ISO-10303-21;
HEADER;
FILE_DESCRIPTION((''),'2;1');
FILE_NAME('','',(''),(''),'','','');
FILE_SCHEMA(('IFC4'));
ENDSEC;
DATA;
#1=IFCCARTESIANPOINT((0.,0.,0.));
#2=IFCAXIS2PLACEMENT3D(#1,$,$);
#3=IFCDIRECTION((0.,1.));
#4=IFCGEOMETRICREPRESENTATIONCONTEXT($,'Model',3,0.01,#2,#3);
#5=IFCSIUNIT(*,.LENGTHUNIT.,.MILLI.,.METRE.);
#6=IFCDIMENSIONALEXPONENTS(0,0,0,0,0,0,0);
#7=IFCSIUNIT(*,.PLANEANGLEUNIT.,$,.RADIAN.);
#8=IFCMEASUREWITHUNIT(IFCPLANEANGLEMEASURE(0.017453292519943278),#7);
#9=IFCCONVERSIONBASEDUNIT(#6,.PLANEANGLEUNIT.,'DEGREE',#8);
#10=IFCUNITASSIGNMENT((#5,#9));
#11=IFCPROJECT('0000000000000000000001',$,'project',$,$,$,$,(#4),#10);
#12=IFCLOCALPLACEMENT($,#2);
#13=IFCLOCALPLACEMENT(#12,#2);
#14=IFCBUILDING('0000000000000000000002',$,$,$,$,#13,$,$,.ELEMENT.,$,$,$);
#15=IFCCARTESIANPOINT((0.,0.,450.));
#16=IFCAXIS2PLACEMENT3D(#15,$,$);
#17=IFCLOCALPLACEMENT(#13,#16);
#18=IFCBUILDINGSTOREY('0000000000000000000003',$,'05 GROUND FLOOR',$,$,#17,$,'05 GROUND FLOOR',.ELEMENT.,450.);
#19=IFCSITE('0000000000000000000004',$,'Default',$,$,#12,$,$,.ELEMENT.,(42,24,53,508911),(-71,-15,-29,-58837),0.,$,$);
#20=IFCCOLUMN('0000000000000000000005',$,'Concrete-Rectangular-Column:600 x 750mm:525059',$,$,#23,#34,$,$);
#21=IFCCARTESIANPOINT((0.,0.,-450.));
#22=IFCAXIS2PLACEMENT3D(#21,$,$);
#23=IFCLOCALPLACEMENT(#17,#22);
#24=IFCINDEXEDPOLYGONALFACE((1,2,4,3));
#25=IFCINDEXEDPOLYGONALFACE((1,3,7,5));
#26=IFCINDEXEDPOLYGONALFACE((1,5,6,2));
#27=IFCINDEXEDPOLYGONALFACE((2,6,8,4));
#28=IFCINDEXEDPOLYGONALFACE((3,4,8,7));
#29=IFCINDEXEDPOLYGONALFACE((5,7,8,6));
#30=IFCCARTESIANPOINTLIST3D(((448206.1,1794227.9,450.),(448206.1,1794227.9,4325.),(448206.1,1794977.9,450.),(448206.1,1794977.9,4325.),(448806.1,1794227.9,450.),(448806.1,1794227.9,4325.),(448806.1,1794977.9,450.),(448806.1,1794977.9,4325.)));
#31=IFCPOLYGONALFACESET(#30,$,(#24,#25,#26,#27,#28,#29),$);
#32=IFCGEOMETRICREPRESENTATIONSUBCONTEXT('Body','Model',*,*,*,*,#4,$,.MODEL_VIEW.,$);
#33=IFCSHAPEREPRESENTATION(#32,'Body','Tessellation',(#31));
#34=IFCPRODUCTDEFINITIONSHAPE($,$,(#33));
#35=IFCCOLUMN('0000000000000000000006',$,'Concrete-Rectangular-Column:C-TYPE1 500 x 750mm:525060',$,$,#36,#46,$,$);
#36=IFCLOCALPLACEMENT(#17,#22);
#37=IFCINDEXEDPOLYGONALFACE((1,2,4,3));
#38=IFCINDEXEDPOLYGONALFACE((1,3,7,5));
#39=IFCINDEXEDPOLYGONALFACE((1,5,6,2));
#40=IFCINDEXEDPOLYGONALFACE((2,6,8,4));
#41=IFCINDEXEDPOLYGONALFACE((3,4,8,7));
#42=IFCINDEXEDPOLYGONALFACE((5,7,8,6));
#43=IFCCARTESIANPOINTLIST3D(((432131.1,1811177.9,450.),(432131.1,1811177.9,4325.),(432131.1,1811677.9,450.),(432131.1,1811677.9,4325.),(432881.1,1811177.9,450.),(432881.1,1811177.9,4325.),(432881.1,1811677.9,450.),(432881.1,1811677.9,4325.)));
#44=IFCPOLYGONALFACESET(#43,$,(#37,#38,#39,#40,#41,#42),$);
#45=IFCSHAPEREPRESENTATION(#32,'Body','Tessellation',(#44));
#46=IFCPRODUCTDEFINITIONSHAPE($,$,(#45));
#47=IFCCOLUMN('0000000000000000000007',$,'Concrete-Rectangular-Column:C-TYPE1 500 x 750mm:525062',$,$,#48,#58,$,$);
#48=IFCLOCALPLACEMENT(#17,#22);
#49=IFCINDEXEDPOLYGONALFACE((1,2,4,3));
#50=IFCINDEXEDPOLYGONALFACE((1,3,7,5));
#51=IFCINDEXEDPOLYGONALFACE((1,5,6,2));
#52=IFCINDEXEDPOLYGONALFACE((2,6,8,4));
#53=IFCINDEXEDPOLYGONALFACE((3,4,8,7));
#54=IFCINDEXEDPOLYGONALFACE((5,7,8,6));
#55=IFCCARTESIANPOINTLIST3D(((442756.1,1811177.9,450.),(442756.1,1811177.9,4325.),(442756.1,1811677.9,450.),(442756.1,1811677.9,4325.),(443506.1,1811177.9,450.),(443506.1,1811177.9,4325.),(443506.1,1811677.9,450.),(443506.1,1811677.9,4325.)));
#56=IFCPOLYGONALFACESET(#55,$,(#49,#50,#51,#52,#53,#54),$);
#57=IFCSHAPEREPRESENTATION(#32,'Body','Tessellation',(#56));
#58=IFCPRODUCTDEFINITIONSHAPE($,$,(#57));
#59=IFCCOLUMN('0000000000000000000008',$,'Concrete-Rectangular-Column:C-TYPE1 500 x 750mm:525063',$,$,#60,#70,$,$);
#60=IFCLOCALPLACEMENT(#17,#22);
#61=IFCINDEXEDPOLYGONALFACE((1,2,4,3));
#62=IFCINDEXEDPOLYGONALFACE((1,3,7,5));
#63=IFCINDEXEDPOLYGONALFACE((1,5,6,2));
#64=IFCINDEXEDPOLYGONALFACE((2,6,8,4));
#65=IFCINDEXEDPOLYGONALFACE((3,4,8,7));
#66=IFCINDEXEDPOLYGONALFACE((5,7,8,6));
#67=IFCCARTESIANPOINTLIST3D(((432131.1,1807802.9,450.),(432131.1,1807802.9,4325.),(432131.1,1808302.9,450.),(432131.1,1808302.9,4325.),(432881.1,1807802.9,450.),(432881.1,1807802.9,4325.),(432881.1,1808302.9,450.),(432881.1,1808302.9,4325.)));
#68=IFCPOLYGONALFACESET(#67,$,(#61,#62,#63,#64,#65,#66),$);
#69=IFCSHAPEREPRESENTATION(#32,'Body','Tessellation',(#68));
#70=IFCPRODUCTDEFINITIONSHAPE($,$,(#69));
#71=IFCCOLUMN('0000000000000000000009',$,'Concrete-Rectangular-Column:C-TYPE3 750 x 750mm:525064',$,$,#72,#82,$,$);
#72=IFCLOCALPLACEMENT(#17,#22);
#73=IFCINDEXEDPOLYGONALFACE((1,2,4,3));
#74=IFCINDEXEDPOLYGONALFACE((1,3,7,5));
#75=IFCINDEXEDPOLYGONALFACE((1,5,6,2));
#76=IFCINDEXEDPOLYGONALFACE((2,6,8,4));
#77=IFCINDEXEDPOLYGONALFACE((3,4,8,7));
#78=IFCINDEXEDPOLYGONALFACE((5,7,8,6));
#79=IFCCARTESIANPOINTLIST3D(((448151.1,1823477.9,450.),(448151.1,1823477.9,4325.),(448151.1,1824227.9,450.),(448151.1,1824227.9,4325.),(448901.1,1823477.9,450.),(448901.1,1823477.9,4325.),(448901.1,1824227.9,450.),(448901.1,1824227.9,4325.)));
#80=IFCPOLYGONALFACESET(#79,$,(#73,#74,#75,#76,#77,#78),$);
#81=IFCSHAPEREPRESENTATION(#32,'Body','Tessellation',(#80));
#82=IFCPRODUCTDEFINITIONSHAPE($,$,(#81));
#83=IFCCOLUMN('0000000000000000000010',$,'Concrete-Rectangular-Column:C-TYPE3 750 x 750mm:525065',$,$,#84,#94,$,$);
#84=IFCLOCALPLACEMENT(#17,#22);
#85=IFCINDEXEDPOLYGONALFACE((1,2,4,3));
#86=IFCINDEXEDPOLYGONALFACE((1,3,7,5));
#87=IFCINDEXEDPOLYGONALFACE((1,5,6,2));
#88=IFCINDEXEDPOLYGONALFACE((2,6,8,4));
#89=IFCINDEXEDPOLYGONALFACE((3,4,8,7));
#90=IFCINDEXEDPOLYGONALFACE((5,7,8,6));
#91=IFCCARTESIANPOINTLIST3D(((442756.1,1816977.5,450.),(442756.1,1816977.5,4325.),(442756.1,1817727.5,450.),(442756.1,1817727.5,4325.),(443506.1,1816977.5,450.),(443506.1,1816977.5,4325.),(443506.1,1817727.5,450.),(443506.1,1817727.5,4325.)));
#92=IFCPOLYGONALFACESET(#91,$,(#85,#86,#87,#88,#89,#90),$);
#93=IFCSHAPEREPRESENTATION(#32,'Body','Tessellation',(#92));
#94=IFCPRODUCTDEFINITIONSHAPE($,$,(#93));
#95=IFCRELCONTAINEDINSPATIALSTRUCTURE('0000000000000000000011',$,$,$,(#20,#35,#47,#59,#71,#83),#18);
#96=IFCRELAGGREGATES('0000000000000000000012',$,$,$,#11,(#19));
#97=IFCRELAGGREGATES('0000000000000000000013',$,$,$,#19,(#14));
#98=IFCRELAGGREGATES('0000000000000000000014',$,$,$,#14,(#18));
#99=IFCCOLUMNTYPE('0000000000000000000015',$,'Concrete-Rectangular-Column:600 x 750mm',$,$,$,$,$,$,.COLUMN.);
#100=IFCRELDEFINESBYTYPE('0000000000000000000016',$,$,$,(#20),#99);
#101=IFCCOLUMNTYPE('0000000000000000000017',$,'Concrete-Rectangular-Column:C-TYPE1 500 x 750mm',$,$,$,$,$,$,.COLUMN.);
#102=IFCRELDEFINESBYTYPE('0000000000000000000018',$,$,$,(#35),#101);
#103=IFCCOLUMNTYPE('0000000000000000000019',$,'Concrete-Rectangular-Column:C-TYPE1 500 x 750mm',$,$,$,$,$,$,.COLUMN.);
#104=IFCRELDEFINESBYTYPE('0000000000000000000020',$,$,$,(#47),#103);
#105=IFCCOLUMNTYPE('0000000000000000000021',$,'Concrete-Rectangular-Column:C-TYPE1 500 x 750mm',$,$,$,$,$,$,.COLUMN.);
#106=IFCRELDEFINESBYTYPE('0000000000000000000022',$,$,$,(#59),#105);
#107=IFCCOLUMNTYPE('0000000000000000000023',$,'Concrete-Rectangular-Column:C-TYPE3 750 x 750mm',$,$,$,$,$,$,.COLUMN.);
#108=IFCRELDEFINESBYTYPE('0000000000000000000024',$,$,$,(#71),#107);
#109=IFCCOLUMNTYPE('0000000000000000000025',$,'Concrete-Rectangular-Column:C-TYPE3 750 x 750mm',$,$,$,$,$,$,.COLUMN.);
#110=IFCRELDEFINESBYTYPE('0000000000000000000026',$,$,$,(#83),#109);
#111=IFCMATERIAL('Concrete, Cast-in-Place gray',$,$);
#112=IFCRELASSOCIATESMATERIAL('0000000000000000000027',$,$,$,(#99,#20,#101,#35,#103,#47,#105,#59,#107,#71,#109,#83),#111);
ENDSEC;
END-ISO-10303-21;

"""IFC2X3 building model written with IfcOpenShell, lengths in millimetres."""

from ifc_helpers import new_model, entity, si_unit, converted_unit, direction, frame, frame_2d, origin, place, context, subcontext, project, spatial, rectangle, extrude, source, transform, mapped, material, type_object, type_shapes, element, save


model = new_model("IFC2X3")

# Units and contexts
model_context = context("Model", 3, precision=0.01, world=origin(), true_north=direction((0.0, 1.0)))
body_context = subcontext(model_context, "Body", "Model", "MODEL_VIEW")
ifc_project = project(units=[si_unit("LENGTHUNIT", "METRE", prefix="MILLI"), converted_unit("PLANEANGLEUNIT", "DEGREE", entity("IfcPlaneAngleMeasure", 0.017453292519943278), si_unit("PLANEANGLEUNIT", "RADIAN"), dimensions=[0, 0, 0, 0, 0, 0, 0])], contexts=[model_context])

# Site, building, storey
site_placement = place(None, origin())
site = spatial("IfcSite", under=ifc_project, at=site_placement, Name="Default", CompositionType="ELEMENT", RefLatitude=(42, 24, 53, 508911), RefLongitude=(-71, -15, -29, -58837), RefElevation=0.0)
building_placement = place(site_placement, origin())
building = spatial("IfcBuilding", under=site, at=building_placement, CompositionType="ELEMENT")
storey_placement = place(building_placement, frame((0.0, 0.0, 450.0)))
storey = spatial("IfcBuildingStorey", under=building, at=storey_placement, Name="05 GROUND FLOOR", LongName="05 GROUND FLOOR", CompositionType="ELEMENT", Elevation=450.0)

# Columns
ifc_material_1 = material(Name="Concrete, Cast-in-Place gray")
column_type_1 = type_object("IfcColumnType", Name="Concrete-Rectangular-Column:600 x 750mm", PredefinedType="COLUMN", material=ifc_material_1)
shared_shape_1 = source(origin(), body_context, "Body", "SweptSolid", [
    extrude(rectangle(XDim=3875.0, YDim=750.0, at=frame_2d((0.0, 0.0), x_axis=(1.0, 0.0))), frame((448206.1, 1794602.9, 2387.5), z_axis=(1.0, 0.0, 0.0), x_axis=(0.0, 0.0, 1.0)), (0.0, 0.0, 1.0), 600.0),
])
type_shapes(column_type_1, [shared_shape_1])
column_1_placement = place(storey_placement, frame((0.0, 0.0, -450.0)))
element("IfcColumn", 1, at=column_1_placement, inside=storey, type_object=column_type_1, material=ifc_material_1, Name="Concrete-Rectangular-Column:600 x 750mm:525059", context=body_context, shape_type="MappedRepresentation", body=[
    mapped(shared_shape_1, transform((0.0, 0.0, 0.0), scale=1.0)),
])
column_type_2 = type_object("IfcColumnType", Name="Concrete-Rectangular-Column:C-TYPE1 500 x 750mm", PredefinedType="COLUMN", material=ifc_material_1)
shared_shape_2 = source(origin(), body_context, "Body", "SweptSolid", [
    extrude(rectangle(XDim=500.0, YDim=750.0, at=frame_2d((0.0, 0.0), x_axis=(1.0, 0.0))), frame((432506.1, 1811427.9, 450.0), z_axis=(0.0, 0.0, 1.0), x_axis=(0.0, -1.0, 0.0)), (0.0, 0.0, 1.0), 3875.0),
])
type_shapes(column_type_2, [shared_shape_2])
column_2_placement = place(storey_placement, frame((0.0, 0.0, -450.0)))
element("IfcColumn", 2, at=column_2_placement, inside=storey, type_object=column_type_2, material=ifc_material_1, Name="Concrete-Rectangular-Column:C-TYPE1 500 x 750mm:525060", context=body_context, shape_type="MappedRepresentation", body=[
    mapped(shared_shape_2, transform((0.0, 0.0, 0.0), scale=1.0)),
])
column_type_3 = type_object("IfcColumnType", Name="Concrete-Rectangular-Column:C-TYPE1 500 x 750mm", PredefinedType="COLUMN", material=ifc_material_1)
shared_shape_3 = source(origin(), body_context, "Body", "SweptSolid", [
    extrude(rectangle(XDim=500.0, YDim=750.0, at=frame_2d((0.0, 0.0), x_axis=(1.0, 0.0))), frame((443131.1, 1811427.9, 450.0), z_axis=(0.0, 0.0, 1.0), x_axis=(0.0, -1.0, 0.0)), (0.0, 0.0, 1.0), 3875.0),
])
type_shapes(column_type_3, [shared_shape_3])
column_3_placement = place(storey_placement, frame((0.0, 0.0, -450.0)))
element("IfcColumn", 3, at=column_3_placement, inside=storey, type_object=column_type_3, material=ifc_material_1, Name="Concrete-Rectangular-Column:C-TYPE1 500 x 750mm:525062", context=body_context, shape_type="MappedRepresentation", body=[
    mapped(shared_shape_3, transform((0.0, 0.0, 0.0), scale=1.0)),
])
column_type_4 = type_object("IfcColumnType", Name="Concrete-Rectangular-Column:C-TYPE1 500 x 750mm", PredefinedType="COLUMN", material=ifc_material_1)
shared_shape_4 = source(origin(), body_context, "Body", "SweptSolid", [
    extrude(rectangle(XDim=500.0, YDim=750.0, at=frame_2d((0.0, 0.0), x_axis=(1.0, 0.0))), frame((432506.1, 1808052.9, 450.0), z_axis=(0.0, 0.0, 1.0), x_axis=(0.0, -1.0, 0.0)), (0.0, 0.0, 1.0), 3875.0),
])
type_shapes(column_type_4, [shared_shape_4])
column_4_placement = place(storey_placement, frame((0.0, 0.0, -450.0)))
element("IfcColumn", 4, at=column_4_placement, inside=storey, type_object=column_type_4, material=ifc_material_1, Name="Concrete-Rectangular-Column:C-TYPE1 500 x 750mm:525063", context=body_context, shape_type="MappedRepresentation", body=[
    mapped(shared_shape_4, transform((0.0, 0.0, 0.0), scale=1.0)),
])
column_type_5 = type_object("IfcColumnType", Name="Concrete-Rectangular-Column:C-TYPE3 750 x 750mm", PredefinedType="COLUMN", material=ifc_material_1)
shared_shape_5 = source(origin(), body_context, "Body", "SweptSolid", [
    extrude(rectangle(XDim=750.0, YDim=750.0, at=frame_2d((0.0, 0.0), x_axis=(1.0, 0.0))), frame((448526.1, 1823852.9, 450.0), z_axis=(0.0, 0.0, 1.0), x_axis=(0.0, -1.0, 0.0)), (0.0, 0.0, 1.0), 3875.0),
])
type_shapes(column_type_5, [shared_shape_5])
column_5_placement = place(storey_placement, frame((0.0, 0.0, -450.0)))
element("IfcColumn", 5, at=column_5_placement, inside=storey, type_object=column_type_5, material=ifc_material_1, Name="Concrete-Rectangular-Column:C-TYPE3 750 x 750mm:525064", context=body_context, shape_type="MappedRepresentation", body=[
    mapped(shared_shape_5, transform((0.0, 0.0, 0.0), scale=1.0)),
])
column_type_6 = type_object("IfcColumnType", Name="Concrete-Rectangular-Column:C-TYPE3 750 x 750mm", PredefinedType="COLUMN", material=ifc_material_1)
shared_shape_6 = source(origin(), body_context, "Body", "SweptSolid", [
    extrude(rectangle(XDim=750.0, YDim=750.0, at=frame_2d((0.0, 0.0), x_axis=(1.0, 0.0))), frame((443131.1, 1817352.5, 450.0), z_axis=(0.0, 0.0, 1.0), x_axis=(0.0, -1.0, 0.0)), (0.0, 0.0, 1.0), 3875.0),
])
type_shapes(column_type_6, [shared_shape_6])
column_6_placement = place(storey_placement, frame((0.0, 0.0, -450.0)))
element("IfcColumn", 6, at=column_6_placement, inside=storey, type_object=column_type_6, material=ifc_material_1, Name="Concrete-Rectangular-Column:C-TYPE3 750 x 750mm:525065", context=body_context, shape_type="MappedRepresentation", body=[
    mapped(shared_shape_6, transform((0.0, 0.0, 0.0), scale=1.0)),
])

save(model, "model.ifc")
